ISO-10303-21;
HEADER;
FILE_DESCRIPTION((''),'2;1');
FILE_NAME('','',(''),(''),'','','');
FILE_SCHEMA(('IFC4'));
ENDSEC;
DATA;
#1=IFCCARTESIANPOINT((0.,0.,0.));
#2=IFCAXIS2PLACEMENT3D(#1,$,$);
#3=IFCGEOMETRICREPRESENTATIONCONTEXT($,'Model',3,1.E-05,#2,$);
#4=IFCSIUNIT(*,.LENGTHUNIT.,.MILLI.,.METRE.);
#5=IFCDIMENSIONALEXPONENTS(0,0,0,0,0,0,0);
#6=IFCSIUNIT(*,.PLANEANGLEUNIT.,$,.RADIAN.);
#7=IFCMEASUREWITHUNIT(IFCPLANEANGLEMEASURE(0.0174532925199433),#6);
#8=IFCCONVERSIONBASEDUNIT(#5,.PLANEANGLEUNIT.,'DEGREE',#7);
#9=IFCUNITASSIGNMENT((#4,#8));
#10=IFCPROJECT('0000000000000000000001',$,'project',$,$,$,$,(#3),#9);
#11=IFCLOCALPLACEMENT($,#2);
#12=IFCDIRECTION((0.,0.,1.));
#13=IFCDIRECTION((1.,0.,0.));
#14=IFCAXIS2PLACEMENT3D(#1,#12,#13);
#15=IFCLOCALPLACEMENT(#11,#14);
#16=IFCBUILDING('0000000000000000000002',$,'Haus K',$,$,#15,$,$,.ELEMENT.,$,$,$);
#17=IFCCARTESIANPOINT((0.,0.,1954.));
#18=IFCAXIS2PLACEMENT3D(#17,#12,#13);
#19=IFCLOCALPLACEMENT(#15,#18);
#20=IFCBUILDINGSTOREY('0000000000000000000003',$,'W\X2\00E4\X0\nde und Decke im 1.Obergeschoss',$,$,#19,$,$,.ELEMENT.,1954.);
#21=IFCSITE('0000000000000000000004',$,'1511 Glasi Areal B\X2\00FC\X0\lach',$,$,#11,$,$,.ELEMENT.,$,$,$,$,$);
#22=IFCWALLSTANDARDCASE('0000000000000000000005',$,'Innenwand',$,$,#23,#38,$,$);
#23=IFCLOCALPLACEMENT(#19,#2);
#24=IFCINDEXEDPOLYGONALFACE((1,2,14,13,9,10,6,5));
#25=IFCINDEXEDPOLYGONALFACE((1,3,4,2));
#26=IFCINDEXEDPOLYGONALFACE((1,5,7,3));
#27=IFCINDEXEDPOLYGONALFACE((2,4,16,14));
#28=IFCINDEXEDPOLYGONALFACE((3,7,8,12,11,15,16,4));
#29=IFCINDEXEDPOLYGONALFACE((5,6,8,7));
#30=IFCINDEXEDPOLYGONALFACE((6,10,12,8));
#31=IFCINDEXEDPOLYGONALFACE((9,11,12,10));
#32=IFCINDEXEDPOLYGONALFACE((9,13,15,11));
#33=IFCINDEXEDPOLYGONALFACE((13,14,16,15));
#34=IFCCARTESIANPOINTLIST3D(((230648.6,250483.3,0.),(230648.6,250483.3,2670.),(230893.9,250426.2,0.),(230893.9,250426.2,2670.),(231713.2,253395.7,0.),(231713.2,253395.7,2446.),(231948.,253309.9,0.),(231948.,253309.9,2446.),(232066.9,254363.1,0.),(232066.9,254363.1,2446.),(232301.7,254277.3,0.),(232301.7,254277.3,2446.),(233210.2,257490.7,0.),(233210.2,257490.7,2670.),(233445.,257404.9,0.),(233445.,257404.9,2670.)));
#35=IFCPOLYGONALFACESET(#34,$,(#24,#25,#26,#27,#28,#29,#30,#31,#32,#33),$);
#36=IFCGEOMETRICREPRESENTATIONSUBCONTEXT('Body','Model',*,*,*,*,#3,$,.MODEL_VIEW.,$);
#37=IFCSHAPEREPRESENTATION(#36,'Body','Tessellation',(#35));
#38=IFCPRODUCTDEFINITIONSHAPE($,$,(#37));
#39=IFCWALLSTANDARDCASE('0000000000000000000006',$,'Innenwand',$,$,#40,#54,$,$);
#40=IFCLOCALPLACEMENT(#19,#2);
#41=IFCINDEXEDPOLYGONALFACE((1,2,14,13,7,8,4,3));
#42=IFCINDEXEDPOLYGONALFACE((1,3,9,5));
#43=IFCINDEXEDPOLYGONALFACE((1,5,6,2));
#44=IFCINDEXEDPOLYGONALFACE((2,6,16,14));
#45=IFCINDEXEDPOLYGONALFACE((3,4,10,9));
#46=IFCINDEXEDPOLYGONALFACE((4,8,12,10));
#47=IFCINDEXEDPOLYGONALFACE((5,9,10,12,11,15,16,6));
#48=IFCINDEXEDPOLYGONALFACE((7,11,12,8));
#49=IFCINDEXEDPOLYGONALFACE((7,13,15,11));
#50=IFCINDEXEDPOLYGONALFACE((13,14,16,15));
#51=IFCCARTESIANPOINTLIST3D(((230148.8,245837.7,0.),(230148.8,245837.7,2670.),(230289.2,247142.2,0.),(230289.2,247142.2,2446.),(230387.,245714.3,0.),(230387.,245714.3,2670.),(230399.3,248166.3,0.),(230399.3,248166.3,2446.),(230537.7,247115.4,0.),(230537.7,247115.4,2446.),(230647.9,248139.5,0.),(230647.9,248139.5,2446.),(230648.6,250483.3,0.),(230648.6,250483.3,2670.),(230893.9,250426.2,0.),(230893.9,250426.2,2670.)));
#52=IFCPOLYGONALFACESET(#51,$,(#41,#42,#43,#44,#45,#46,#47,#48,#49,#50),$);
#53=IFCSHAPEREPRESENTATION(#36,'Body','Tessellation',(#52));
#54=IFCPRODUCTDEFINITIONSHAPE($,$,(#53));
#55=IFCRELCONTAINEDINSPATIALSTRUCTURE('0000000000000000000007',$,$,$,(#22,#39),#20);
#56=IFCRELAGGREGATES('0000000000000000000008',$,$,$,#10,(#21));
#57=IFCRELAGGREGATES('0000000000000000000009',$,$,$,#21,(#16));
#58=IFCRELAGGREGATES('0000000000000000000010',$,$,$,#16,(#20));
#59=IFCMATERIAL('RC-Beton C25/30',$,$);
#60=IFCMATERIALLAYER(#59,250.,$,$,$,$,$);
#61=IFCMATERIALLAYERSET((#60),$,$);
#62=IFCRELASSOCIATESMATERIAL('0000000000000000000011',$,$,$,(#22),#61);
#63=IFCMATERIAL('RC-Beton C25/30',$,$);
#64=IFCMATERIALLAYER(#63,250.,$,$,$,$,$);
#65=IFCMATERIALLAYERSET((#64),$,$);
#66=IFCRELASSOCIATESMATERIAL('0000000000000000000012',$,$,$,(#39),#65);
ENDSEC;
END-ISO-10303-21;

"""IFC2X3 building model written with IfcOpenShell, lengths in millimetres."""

from ifc_helpers import new_model, entity, si_unit, converted_unit, frame, frame_2d, origin, origin_with_axes, place, context, subcontext, project, spatial, polyline, rectangle, outline, extrude, material, layer, layer_set, layer_usage, element, save


model = new_model("IFC2X3")

# Units and contexts
model_context = context("Model", 3, precision=1e-05, world=origin())
body_context = subcontext(model_context, "Body", "Model", "MODEL_VIEW")
ifc_project = project(units=[si_unit("LENGTHUNIT", "METRE", prefix="MILLI"), converted_unit("PLANEANGLEUNIT", "DEGREE", entity("IfcPlaneAngleMeasure", 0.0174532925199433), si_unit("PLANEANGLEUNIT", "RADIAN"), dimensions=[0, 0, 0, 0, 0, 0, 0])], contexts=[model_context])

# Site, building, storey
site_placement = place(None, origin())
site = spatial("IfcSite", under=ifc_project, at=site_placement, Name="1511 Glasi Areal Bülach", CompositionType="ELEMENT")
building_placement = place(site_placement, origin_with_axes())
building = spatial("IfcBuilding", under=site, at=building_placement, Name="Haus K", CompositionType="ELEMENT")
storey_placement = place(building_placement, frame((0.0, 0.0, 1954.0), z_axis=(0.0, 0.0, 1.0), x_axis=(1.0, 0.0, 0.0)))
storey = spatial("IfcBuildingStorey", under=building, at=storey_placement, Name="Wände und Decke im 1.Obergeschoss", CompositionType="ELEMENT", Elevation=1954.0)

# Walls, openings
ifc_material_1 = material(Name="RC-Beton C25/30")
ifc_layer_1 = layer(ifc_material_1, 250.0)
ifc_layer_set_1 = layer_set([ifc_layer_1])
ifc_layer_usage_1 = layer_usage(ifc_layer_set_1, "AXIS2", "POSITIVE", 0.0)
wall_1_placement = place(storey_placement, frame((230893.9, 250426.2, 0.0), z_axis=(0.0, 0.0, 1.0), x_axis=(0.343332, 0.939214, 0.0)))
wall_1 = element("IfcWallStandardCase", 1, at=wall_1_placement, inside=storey, material=ifc_layer_usage_1, Name="Innenwand", context=body_context, shape_type="SweptSolid", body=[
    extrude(outline(polyline([(0.0, 0.0), (7430.3, 0.0), (7430.3, 250.0), (-30.6, 250.0), (0.0, 0.0)])), origin_with_axes(), (0.0, 0.0, 1.0), 2670.0),
])
opening_1_placement = place(wall_1_placement, frame((3070.3, 0.0, 0.0), z_axis=(0.0, 1.0, 0.0), x_axis=(0.0, 0.0, 1.0)))
element("IfcOpeningElement", 2, at=opening_1_placement, cuts=wall_1, ObjectType="Opening", context=body_context, shape_type="SweptSolid", body=[
    extrude(rectangle(XDim=2446.0, YDim=1030.0, at=frame_2d((1223.0, 515.0), x_axis=(1.0, 0.0))), origin_with_axes(), (0.0, 0.0, 1.0), 250.0),
])
ifc_material_2 = material(Name="RC-Beton C25/30")
ifc_layer_2 = layer(ifc_material_2, 250.0)
ifc_layer_set_2 = layer_set([ifc_layer_2])
ifc_layer_usage_2 = layer_usage(ifc_layer_set_2, "AXIS2", "POSITIVE", 0.0)
wall_2_placement = place(storey_placement, frame((230387.0, 245714.3, 0.0), z_axis=(0.0, 0.0, 1.0), x_axis=(0.106958, 0.994264, 0.0)))
wall_2 = element("IfcWallStandardCase", 3, at=wall_2_placement, inside=storey, material=ifc_layer_usage_2, Name="Innenwand", context=body_context, shape_type="SweptSolid", body=[
    extrude(outline(polyline([(0.0, 0.0), (4739.1, 0.0), (4769.7, 250.0), (97.3, 250.0), (0.0, 0.0)])), origin_with_axes(), (0.0, 0.0, 1.0), 2670.0),
])
opening_2_placement = place(wall_2_placement, frame((1409.2, 0.0, 0.0), z_axis=(0.0, 1.0, 0.0), x_axis=(0.0, 0.0, 1.0)))
element("IfcOpeningElement", 4, at=opening_2_placement, cuts=wall_2, ObjectType="Opening", context=body_context, shape_type="SweptSolid", body=[
    extrude(rectangle(XDim=2446.0, YDim=1030.0, at=frame_2d((1223.0, 515.0), x_axis=(1.0, 0.0))), origin_with_axes(), (0.0, 0.0, 1.0), 250.0),
])

save(model, "model.ifc")
